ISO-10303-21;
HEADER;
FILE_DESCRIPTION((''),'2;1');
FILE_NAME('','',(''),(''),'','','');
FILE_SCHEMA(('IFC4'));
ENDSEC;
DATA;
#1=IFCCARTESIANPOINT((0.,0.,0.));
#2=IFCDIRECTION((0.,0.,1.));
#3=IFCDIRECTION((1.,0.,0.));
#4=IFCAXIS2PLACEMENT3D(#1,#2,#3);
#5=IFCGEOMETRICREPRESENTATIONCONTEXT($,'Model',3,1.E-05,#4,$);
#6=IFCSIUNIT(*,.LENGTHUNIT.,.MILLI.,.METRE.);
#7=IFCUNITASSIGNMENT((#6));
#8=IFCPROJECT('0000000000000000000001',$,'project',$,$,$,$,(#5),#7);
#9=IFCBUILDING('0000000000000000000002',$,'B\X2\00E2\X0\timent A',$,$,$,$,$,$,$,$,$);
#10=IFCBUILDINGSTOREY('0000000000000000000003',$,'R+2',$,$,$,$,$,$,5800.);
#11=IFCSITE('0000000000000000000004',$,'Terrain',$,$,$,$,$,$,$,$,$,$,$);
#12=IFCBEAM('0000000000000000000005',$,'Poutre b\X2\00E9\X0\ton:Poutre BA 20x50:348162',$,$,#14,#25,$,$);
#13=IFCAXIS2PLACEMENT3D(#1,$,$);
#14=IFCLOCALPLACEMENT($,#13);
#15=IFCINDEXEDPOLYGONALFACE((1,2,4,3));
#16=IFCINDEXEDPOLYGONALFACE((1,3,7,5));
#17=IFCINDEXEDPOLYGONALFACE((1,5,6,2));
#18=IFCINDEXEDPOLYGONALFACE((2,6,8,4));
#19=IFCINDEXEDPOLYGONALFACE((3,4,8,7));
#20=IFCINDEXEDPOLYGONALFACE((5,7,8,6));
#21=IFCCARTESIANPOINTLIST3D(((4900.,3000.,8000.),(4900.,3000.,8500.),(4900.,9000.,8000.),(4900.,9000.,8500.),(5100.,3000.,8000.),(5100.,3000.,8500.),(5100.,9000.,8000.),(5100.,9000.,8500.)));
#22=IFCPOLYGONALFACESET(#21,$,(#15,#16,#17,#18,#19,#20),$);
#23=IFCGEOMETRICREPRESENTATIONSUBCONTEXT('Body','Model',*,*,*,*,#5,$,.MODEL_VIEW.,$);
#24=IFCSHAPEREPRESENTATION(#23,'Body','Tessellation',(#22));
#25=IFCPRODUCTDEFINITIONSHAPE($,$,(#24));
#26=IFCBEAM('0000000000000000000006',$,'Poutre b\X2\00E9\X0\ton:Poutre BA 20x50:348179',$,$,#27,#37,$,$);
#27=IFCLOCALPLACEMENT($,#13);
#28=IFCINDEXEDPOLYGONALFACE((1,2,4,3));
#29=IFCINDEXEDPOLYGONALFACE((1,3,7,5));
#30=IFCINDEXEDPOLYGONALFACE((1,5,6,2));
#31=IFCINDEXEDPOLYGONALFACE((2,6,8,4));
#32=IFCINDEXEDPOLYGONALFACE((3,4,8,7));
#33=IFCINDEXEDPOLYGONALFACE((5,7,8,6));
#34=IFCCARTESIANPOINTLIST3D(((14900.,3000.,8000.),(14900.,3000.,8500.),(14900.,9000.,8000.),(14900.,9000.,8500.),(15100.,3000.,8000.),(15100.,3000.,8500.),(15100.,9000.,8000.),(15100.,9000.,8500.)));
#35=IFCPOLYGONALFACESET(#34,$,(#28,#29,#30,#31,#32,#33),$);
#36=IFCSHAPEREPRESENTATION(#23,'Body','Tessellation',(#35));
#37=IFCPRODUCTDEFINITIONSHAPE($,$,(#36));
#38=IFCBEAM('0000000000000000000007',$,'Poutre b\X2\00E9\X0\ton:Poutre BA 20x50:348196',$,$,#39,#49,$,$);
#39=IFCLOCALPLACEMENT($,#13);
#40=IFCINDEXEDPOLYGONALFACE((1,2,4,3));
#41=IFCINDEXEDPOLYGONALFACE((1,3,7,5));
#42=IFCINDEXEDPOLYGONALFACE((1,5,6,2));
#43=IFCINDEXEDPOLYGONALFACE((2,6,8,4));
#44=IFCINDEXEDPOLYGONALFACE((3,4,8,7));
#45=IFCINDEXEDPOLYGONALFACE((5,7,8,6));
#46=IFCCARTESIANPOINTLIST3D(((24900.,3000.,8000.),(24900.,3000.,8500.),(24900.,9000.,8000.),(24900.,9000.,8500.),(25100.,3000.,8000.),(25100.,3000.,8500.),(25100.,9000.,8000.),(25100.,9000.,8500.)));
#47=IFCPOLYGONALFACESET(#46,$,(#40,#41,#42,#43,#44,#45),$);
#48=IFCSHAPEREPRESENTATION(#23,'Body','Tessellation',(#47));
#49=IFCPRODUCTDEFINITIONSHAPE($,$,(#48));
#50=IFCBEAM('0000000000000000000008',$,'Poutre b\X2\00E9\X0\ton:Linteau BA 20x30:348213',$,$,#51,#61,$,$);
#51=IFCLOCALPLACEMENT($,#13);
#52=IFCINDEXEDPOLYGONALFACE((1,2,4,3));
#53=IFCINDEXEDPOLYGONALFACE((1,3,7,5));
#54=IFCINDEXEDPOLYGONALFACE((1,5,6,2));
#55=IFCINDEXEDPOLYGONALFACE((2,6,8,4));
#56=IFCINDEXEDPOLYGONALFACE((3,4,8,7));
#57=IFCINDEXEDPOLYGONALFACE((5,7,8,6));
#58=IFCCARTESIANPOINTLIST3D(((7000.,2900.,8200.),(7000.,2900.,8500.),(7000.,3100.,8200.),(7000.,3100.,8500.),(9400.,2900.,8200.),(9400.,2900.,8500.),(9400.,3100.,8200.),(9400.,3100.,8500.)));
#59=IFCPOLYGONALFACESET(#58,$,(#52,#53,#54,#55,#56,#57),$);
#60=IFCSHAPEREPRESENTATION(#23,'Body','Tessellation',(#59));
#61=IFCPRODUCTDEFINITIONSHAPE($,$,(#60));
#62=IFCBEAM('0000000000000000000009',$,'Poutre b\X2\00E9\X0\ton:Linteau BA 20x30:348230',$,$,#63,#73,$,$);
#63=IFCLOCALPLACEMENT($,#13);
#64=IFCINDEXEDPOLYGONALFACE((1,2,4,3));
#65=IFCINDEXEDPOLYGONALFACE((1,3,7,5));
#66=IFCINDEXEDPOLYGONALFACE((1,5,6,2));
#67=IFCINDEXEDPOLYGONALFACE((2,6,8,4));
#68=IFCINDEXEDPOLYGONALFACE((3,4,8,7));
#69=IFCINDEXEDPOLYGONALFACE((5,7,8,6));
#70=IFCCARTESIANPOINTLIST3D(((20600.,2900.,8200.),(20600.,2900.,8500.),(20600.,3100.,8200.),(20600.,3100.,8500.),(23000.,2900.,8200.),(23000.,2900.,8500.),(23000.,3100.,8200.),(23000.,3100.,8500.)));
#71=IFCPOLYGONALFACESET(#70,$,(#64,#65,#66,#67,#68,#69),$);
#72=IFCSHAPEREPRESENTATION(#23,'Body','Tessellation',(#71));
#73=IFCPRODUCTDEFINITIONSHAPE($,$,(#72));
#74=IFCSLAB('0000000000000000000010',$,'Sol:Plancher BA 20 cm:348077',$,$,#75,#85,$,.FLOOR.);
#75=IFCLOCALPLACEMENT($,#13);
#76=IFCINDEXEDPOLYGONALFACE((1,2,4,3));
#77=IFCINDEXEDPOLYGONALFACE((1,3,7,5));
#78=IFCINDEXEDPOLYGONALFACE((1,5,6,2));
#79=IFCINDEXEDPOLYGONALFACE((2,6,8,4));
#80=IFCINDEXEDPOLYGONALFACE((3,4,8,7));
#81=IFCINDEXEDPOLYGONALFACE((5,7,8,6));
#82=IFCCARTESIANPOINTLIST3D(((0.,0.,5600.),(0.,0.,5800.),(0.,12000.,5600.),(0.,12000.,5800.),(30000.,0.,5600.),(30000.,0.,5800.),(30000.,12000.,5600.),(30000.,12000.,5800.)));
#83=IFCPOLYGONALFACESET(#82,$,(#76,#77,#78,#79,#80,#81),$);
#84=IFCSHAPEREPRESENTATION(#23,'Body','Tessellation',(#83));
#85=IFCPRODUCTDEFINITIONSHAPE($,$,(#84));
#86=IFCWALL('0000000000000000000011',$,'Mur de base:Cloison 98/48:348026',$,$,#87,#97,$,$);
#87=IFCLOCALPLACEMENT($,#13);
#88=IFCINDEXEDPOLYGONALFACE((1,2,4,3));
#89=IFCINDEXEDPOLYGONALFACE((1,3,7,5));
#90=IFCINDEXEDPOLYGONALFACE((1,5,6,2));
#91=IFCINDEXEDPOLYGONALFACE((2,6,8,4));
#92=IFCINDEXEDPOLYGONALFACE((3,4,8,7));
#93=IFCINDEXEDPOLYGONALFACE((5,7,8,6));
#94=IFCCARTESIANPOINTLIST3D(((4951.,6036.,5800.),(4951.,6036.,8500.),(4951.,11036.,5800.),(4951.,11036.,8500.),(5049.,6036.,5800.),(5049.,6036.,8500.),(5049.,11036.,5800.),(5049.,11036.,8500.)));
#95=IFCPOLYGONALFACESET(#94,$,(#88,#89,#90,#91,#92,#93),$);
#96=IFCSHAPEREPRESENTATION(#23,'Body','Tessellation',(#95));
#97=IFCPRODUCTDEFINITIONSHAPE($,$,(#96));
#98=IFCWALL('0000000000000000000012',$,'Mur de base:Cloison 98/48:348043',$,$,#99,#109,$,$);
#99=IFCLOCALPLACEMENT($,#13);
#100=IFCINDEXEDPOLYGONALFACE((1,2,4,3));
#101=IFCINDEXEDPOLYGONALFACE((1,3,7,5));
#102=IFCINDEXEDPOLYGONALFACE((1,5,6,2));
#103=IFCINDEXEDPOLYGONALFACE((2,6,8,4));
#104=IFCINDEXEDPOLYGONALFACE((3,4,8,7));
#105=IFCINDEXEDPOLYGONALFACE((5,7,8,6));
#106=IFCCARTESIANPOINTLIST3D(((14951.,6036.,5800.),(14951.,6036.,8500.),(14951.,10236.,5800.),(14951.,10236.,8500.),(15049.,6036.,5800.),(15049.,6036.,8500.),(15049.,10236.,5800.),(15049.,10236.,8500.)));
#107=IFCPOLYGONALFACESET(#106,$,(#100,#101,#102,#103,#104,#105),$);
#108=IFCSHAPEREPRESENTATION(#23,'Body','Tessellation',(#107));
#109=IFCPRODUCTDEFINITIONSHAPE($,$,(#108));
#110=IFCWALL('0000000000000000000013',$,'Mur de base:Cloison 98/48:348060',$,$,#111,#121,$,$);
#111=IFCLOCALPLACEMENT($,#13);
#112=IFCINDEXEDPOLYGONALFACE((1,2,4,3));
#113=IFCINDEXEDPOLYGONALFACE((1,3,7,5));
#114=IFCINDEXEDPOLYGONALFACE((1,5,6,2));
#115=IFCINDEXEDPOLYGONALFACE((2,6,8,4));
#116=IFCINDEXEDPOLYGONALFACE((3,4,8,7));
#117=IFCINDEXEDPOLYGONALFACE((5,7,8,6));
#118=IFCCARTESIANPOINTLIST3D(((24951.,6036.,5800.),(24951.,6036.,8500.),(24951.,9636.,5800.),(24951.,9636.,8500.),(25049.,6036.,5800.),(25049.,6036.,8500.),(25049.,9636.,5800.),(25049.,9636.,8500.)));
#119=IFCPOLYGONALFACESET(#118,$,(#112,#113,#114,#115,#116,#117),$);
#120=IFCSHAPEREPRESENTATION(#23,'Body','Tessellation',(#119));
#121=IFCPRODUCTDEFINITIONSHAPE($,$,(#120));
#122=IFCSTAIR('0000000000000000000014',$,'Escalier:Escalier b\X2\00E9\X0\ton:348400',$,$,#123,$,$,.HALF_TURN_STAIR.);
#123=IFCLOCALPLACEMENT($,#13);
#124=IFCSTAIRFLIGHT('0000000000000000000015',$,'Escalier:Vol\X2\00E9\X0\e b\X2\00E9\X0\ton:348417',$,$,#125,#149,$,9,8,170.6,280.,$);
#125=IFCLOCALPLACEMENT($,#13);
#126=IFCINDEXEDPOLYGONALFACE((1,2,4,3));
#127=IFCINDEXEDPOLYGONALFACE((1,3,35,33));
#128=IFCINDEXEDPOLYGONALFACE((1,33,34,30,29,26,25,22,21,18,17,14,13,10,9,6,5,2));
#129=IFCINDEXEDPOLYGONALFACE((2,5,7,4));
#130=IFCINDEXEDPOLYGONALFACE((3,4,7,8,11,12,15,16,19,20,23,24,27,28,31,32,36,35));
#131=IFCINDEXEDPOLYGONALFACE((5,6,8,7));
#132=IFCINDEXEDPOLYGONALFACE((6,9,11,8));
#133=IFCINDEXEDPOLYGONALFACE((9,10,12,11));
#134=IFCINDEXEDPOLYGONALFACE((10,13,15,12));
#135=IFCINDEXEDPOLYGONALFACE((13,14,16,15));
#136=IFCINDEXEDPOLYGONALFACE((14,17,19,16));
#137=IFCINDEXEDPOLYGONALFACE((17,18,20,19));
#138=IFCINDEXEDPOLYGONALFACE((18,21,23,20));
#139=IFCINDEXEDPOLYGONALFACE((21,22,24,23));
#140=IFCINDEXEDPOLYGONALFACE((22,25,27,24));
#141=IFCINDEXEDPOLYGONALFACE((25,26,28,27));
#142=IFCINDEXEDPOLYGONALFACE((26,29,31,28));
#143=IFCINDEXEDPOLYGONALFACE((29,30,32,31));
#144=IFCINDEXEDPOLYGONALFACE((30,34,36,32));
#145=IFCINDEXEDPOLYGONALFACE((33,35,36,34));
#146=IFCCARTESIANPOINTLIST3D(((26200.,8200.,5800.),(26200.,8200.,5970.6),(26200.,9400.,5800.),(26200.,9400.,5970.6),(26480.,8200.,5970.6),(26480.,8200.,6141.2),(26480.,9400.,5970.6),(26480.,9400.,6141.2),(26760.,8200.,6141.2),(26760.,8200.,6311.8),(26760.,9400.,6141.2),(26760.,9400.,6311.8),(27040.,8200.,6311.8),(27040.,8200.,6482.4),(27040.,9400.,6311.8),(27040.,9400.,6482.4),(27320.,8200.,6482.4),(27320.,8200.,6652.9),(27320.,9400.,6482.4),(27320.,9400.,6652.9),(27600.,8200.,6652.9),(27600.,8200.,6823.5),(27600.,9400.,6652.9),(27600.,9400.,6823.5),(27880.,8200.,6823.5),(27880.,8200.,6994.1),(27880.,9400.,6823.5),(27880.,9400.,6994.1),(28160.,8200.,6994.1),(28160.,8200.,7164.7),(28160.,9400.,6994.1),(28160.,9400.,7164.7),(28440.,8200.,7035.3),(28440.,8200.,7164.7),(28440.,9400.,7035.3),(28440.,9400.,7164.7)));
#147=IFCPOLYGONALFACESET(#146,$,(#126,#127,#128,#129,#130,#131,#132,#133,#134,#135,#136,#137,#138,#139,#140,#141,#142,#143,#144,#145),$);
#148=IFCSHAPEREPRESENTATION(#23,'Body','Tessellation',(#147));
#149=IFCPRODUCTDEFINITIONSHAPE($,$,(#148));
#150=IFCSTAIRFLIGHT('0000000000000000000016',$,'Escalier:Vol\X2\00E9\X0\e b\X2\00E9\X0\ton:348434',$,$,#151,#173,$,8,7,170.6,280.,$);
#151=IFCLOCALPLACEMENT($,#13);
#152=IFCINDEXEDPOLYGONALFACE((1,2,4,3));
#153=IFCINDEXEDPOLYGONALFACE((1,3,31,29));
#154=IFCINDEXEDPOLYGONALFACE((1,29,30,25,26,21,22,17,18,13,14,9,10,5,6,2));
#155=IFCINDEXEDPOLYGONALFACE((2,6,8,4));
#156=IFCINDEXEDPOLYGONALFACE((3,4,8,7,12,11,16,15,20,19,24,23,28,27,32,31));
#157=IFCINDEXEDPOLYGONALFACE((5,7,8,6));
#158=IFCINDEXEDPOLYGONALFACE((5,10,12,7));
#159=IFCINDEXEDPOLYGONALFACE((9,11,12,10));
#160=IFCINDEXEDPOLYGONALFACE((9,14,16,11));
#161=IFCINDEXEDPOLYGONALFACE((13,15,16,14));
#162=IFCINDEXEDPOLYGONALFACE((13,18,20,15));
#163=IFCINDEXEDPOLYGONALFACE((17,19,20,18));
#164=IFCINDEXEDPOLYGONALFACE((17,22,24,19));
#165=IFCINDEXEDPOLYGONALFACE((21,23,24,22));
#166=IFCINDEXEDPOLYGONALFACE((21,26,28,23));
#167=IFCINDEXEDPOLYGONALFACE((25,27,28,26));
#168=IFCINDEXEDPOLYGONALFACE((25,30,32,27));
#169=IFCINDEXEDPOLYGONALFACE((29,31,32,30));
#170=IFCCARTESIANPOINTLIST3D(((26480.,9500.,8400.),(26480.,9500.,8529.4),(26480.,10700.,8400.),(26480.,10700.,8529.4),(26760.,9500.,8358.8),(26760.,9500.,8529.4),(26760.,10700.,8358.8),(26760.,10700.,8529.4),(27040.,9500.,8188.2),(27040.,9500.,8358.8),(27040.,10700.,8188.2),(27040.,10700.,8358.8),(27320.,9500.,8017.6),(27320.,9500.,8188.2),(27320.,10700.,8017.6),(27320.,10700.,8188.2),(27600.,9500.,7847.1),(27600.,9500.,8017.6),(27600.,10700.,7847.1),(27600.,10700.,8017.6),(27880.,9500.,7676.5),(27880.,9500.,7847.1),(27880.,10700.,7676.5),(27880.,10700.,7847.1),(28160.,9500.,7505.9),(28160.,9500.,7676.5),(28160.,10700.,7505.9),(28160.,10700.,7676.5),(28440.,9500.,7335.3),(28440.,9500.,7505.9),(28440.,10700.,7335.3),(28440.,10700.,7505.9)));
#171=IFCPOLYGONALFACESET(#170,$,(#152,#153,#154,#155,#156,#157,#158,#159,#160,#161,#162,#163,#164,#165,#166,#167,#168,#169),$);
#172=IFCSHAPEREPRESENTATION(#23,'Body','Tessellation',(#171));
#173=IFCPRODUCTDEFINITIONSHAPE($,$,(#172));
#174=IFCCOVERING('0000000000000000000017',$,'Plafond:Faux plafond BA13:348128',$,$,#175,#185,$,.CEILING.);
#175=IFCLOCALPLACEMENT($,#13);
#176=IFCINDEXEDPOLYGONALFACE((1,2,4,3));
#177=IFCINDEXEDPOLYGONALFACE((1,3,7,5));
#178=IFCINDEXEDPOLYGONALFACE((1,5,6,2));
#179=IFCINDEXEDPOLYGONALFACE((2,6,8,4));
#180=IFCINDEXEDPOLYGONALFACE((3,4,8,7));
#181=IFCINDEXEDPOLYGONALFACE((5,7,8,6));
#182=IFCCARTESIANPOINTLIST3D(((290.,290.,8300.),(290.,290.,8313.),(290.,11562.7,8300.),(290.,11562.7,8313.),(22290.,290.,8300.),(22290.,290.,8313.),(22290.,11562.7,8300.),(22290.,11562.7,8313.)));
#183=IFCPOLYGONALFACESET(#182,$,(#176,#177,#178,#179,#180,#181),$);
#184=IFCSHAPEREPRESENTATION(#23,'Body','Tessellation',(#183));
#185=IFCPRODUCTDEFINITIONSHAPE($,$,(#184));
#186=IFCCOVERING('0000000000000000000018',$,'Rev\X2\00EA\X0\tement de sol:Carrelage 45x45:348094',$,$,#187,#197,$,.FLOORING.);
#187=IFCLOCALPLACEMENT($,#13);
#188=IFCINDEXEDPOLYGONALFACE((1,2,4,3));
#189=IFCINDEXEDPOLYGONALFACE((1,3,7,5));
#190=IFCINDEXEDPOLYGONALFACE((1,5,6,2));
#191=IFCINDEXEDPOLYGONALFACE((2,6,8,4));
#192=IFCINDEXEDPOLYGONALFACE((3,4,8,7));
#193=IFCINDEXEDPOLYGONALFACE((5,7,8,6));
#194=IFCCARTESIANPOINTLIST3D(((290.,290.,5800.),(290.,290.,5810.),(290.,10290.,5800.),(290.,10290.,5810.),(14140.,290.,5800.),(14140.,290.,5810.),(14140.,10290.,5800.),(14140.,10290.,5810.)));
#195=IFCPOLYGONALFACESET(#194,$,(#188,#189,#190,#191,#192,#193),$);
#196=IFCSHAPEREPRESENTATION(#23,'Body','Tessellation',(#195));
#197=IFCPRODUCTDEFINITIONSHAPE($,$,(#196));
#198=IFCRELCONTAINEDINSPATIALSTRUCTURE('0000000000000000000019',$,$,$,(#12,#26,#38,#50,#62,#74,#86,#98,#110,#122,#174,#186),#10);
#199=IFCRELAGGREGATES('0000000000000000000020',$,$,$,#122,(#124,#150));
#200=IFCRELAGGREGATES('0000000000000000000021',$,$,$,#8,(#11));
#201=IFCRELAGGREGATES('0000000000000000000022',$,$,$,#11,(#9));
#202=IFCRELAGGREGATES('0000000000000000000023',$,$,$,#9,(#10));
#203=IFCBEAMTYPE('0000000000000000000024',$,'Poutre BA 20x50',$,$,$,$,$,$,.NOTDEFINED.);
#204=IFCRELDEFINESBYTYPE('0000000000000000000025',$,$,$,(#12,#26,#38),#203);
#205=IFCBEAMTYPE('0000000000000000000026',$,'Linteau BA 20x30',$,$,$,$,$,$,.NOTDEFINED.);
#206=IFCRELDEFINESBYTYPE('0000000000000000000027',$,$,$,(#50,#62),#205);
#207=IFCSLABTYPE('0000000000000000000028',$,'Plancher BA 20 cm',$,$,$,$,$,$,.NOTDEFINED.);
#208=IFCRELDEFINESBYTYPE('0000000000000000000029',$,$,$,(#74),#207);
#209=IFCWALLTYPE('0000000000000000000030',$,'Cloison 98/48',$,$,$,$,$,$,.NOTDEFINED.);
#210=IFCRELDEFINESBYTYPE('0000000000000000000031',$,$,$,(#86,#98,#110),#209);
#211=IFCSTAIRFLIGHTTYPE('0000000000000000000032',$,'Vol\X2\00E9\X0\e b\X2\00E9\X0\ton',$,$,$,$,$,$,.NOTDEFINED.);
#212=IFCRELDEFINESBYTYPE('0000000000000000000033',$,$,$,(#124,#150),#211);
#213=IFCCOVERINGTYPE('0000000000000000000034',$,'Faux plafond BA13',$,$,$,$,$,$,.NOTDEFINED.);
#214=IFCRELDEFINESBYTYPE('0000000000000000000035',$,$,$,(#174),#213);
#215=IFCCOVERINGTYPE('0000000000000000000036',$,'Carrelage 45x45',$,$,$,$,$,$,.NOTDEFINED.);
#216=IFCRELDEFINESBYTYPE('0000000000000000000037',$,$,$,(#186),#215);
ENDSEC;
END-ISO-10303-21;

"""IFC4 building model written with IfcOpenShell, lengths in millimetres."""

from ifc_helpers import new_model, si_unit, frame, frame_2d, origin_with_axes, place, context, subcontext, project, spatial, polyline, rectangle, outline, extrude, type_object, element, aggregate, save


model = new_model("IFC4")

# Units and contexts
model_context = context("Model", 3, precision=1e-05, world=origin_with_axes())
body_context = subcontext(model_context, "Body", "Model", "MODEL_VIEW")
ifc_project = project(units=[si_unit("LENGTHUNIT", "METRE", prefix="MILLI")], contexts=[model_context])

# Site, building, storey
site = spatial("IfcSite", under=ifc_project, Name="Terrain")
building = spatial("IfcBuilding", under=site, Name="Bâtiment A")
storey = spatial("IfcBuildingStorey", under=building, Name="R+2", Elevation=5800.0)

# Beams
beam_type_1 = type_object("IfcBeamType", Name="Poutre BA 20x50", PredefinedType="NOTDEFINED")
beam_1_placement = place(None, origin_with_axes())
element("IfcBeam", 1, at=beam_1_placement, inside=storey, type_object=beam_type_1, Name="Poutre béton:Poutre BA 20x50:348162", context=body_context, shape_type="SweptSolid", body=[
    extrude(rectangle(XDim=200.0, YDim=6000.0, at=frame_2d((5000.0, 6000.0))), frame((0.0, 0.0, 8000.0), z_axis=(0.0, 0.0, 1.0), x_axis=(1.0, 0.0, 0.0)), (0.0, 0.0, 1.0), 500.0),
])
beam_2_placement = place(None, origin_with_axes())
element("IfcBeam", 2, at=beam_2_placement, inside=storey, type_object=beam_type_1, Name="Poutre béton:Poutre BA 20x50:348179", context=body_context, shape_type="SweptSolid", body=[
    extrude(rectangle(XDim=200.0, YDim=6000.0, at=frame_2d((15000.0, 6000.0))), frame((0.0, 0.0, 8000.0), z_axis=(0.0, 0.0, 1.0), x_axis=(1.0, 0.0, 0.0)), (0.0, 0.0, 1.0), 500.0),
])
beam_3_placement = place(None, origin_with_axes())
element("IfcBeam", 3, at=beam_3_placement, inside=storey, type_object=beam_type_1, Name="Poutre béton:Poutre BA 20x50:348196", context=body_context, shape_type="SweptSolid", body=[
    extrude(rectangle(XDim=200.0, YDim=6000.0, at=frame_2d((25000.0, 6000.0))), frame((0.0, 0.0, 8000.0), z_axis=(0.0, 0.0, 1.0), x_axis=(1.0, 0.0, 0.0)), (0.0, 0.0, 1.0), 500.0),
])
beam_type_2 = type_object("IfcBeamType", Name="Linteau BA 20x30", PredefinedType="NOTDEFINED")
beam_4_placement = place(None, origin_with_axes())
element("IfcBeam", 4, at=beam_4_placement, inside=storey, type_object=beam_type_2, Name="Poutre béton:Linteau BA 20x30:348213", context=body_context, shape_type="SweptSolid", body=[
    extrude(rectangle(XDim=2400.0, YDim=200.0, at=frame_2d((8200.0, 3000.0))), frame((0.0, 0.0, 8200.0), z_axis=(0.0, 0.0, 1.0), x_axis=(1.0, 0.0, 0.0)), (0.0, 0.0, 1.0), 300.0),
])
beam_5_placement = place(None, origin_with_axes())
element("IfcBeam", 5, at=beam_5_placement, inside=storey, type_object=beam_type_2, Name="Poutre béton:Linteau BA 20x30:348230", context=body_context, shape_type="SweptSolid", body=[
    extrude(rectangle(XDim=2400.0, YDim=200.0, at=frame_2d((21800.0, 3000.0))), frame((0.0, 0.0, 8200.0), z_axis=(0.0, 0.0, 1.0), x_axis=(1.0, 0.0, 0.0)), (0.0, 0.0, 1.0), 300.0),
])

# Slab
slab_type = type_object("IfcSlabType", Name="Plancher BA 20 cm", PredefinedType="NOTDEFINED")
slab_placement = place(None, origin_with_axes())
element("IfcSlab", 6, at=slab_placement, inside=storey, type_object=slab_type, Name="Sol:Plancher BA 20 cm:348077", PredefinedType="FLOOR", context=body_context, shape_type="SweptSolid", body=[
    extrude(rectangle(XDim=30000.0, YDim=12000.0, at=frame_2d((15000.0, 6000.0))), frame((0.0, 0.0, 5600.0), z_axis=(0.0, 0.0, 1.0), x_axis=(1.0, 0.0, 0.0)), (0.0, 0.0, 1.0), 200.0),
])

# Walls
wall_type = type_object("IfcWallType", Name="Cloison 98/48", PredefinedType="NOTDEFINED")
wall_1_placement = place(None, origin_with_axes())
element("IfcWall", 7, at=wall_1_placement, inside=storey, type_object=wall_type, Name="Mur de base:Cloison 98/48:348026", context=body_context, shape_type="SweptSolid", body=[
    extrude(rectangle(XDim=98.0, YDim=5000.0, at=frame_2d((5000.0, 8536.0))), frame((0.0, 0.0, 5800.0), z_axis=(0.0, 0.0, 1.0), x_axis=(1.0, 0.0, 0.0)), (0.0, 0.0, 1.0), 2700.0),
])
wall_2_placement = place(None, origin_with_axes())
element("IfcWall", 8, at=wall_2_placement, inside=storey, type_object=wall_type, Name="Mur de base:Cloison 98/48:348043", context=body_context, shape_type="SweptSolid", body=[
    extrude(rectangle(XDim=98.0, YDim=4200.0, at=frame_2d((15000.0, 8136.0))), frame((0.0, 0.0, 5800.0), z_axis=(0.0, 0.0, 1.0), x_axis=(1.0, 0.0, 0.0)), (0.0, 0.0, 1.0), 2700.0),
])
wall_3_placement = place(None, origin_with_axes())
element("IfcWall", 9, at=wall_3_placement, inside=storey, type_object=wall_type, Name="Mur de base:Cloison 98/48:348060", context=body_context, shape_type="SweptSolid", body=[
    extrude(rectangle(XDim=98.0, YDim=3600.0, at=frame_2d((25000.0, 7836.0))), frame((0.0, 0.0, 5800.0), z_axis=(0.0, 0.0, 1.0), x_axis=(1.0, 0.0, 0.0)), (0.0, 0.0, 1.0), 2700.0),
])

# Stair, stair flights
stair = element("IfcStair", 10, inside=storey, Name="Escalier:Escalier béton:348400", PredefinedType="HALF_TURN_STAIR")
stair_flight_type = type_object("IfcStairFlightType", Name="Volée béton", PredefinedType="NOTDEFINED")
stair_flight_1_placement = place(None, origin_with_axes())
stair_flight_1 = element("IfcStairFlight", 11, at=stair_flight_1_placement, type_object=stair_flight_type, Name="Escalier:Volée béton:348417", NumberOfRisers=9, NumberOfTreads=8, RiserHeight=170.6, TreadLength=280.0, context=body_context, shape_type="SweptSolid", body=[
    extrude(outline(polyline([(0.0, 0.0), (0.0, 170.6), (280.0, 170.6), (280.0, 341.2), (560.0, 341.2), (560.0, 511.8), (840.0, 511.8), (840.0, 682.4), (1120.0, 682.4), (1120.0, 852.9), (1400.0, 852.9), (1400.0, 1023.5), (1680.0, 1023.5), (1680.0, 1194.1), (1960.0, 1194.1), (1960.0, 1364.7), (2240.0, 1364.7), (2240.0, 1535.3), (2240.0, 1235.3), (0.0, 0.0)])), frame((26200.0, 9400.0, 5800.0), z_axis=(0.0, -1.0, 0.0), x_axis=(1.0, 0.0, 0.0)), (0.0, 0.0, 1.0), 1200.0),
])
stair_flight_2_placement = place(None, origin_with_axes())
stair_flight_2 = element("IfcStairFlight", 12, at=stair_flight_2_placement, type_object=stair_flight_type, Name="Escalier:Volée béton:348434", NumberOfRisers=8, NumberOfTreads=7, RiserHeight=170.6, TreadLength=280.0, context=body_context, shape_type="SweptSolid", body=[
    extrude(outline(polyline([(0.0, 0.0), (0.0, 170.6), (280.0, 170.6), (280.0, 341.2), (560.0, 341.2), (560.0, 511.8), (840.0, 511.8), (840.0, 682.4), (1120.0, 682.4), (1120.0, 852.9), (1400.0, 852.9), (1400.0, 1023.5), (1680.0, 1023.5), (1680.0, 1194.1), (1960.0, 1194.1), (1960.0, 1364.7), (1960.0, 1064.7), (0.0, 0.0)])), frame((28440.0, 9500.0, 7335.3), z_axis=(0.0, 1.0, 0.0), x_axis=(-1.0, 0.0, 0.0)), (0.0, 0.0, 1.0), 1200.0),
])
aggregate(stair, [stair_flight_1, stair_flight_2])

# Coverings
covering_type_1 = type_object("IfcCoveringType", Name="Faux plafond BA13", PredefinedType="NOTDEFINED")
covering_1_placement = place(None, origin_with_axes())
element("IfcCovering", 13, at=covering_1_placement, inside=storey, type_object=covering_type_1, Name="Plafond:Faux plafond BA13:348128", PredefinedType="CEILING", context=body_context, shape_type="SweptSolid", body=[
    extrude(rectangle(XDim=22000.0, YDim=11272.7, at=frame_2d((11290.0, 5926.4))), frame((0.0, 0.0, 8300.0), z_axis=(0.0, 0.0, 1.0), x_axis=(1.0, 0.0, 0.0)), (0.0, 0.0, 1.0), 13.0),
])
covering_type_2 = type_object("IfcCoveringType", Name="Carrelage 45x45", PredefinedType="NOTDEFINED")
covering_2_placement = place(None, origin_with_axes())
element("IfcCovering", 14, at=covering_2_placement, inside=storey, type_object=covering_type_2, Name="Revêtement de sol:Carrelage 45x45:348094", PredefinedType="FLOORING", context=body_context, shape_type="SweptSolid", body=[
    extrude(rectangle(XDim=13850.0, YDim=10000.0, at=frame_2d((7215.0, 5290.0))), frame((0.0, 0.0, 5800.0), z_axis=(0.0, 0.0, 1.0), x_axis=(1.0, 0.0, 0.0)), (0.0, 0.0, 1.0), 10.0),
])

save(model, "model.ifc")
